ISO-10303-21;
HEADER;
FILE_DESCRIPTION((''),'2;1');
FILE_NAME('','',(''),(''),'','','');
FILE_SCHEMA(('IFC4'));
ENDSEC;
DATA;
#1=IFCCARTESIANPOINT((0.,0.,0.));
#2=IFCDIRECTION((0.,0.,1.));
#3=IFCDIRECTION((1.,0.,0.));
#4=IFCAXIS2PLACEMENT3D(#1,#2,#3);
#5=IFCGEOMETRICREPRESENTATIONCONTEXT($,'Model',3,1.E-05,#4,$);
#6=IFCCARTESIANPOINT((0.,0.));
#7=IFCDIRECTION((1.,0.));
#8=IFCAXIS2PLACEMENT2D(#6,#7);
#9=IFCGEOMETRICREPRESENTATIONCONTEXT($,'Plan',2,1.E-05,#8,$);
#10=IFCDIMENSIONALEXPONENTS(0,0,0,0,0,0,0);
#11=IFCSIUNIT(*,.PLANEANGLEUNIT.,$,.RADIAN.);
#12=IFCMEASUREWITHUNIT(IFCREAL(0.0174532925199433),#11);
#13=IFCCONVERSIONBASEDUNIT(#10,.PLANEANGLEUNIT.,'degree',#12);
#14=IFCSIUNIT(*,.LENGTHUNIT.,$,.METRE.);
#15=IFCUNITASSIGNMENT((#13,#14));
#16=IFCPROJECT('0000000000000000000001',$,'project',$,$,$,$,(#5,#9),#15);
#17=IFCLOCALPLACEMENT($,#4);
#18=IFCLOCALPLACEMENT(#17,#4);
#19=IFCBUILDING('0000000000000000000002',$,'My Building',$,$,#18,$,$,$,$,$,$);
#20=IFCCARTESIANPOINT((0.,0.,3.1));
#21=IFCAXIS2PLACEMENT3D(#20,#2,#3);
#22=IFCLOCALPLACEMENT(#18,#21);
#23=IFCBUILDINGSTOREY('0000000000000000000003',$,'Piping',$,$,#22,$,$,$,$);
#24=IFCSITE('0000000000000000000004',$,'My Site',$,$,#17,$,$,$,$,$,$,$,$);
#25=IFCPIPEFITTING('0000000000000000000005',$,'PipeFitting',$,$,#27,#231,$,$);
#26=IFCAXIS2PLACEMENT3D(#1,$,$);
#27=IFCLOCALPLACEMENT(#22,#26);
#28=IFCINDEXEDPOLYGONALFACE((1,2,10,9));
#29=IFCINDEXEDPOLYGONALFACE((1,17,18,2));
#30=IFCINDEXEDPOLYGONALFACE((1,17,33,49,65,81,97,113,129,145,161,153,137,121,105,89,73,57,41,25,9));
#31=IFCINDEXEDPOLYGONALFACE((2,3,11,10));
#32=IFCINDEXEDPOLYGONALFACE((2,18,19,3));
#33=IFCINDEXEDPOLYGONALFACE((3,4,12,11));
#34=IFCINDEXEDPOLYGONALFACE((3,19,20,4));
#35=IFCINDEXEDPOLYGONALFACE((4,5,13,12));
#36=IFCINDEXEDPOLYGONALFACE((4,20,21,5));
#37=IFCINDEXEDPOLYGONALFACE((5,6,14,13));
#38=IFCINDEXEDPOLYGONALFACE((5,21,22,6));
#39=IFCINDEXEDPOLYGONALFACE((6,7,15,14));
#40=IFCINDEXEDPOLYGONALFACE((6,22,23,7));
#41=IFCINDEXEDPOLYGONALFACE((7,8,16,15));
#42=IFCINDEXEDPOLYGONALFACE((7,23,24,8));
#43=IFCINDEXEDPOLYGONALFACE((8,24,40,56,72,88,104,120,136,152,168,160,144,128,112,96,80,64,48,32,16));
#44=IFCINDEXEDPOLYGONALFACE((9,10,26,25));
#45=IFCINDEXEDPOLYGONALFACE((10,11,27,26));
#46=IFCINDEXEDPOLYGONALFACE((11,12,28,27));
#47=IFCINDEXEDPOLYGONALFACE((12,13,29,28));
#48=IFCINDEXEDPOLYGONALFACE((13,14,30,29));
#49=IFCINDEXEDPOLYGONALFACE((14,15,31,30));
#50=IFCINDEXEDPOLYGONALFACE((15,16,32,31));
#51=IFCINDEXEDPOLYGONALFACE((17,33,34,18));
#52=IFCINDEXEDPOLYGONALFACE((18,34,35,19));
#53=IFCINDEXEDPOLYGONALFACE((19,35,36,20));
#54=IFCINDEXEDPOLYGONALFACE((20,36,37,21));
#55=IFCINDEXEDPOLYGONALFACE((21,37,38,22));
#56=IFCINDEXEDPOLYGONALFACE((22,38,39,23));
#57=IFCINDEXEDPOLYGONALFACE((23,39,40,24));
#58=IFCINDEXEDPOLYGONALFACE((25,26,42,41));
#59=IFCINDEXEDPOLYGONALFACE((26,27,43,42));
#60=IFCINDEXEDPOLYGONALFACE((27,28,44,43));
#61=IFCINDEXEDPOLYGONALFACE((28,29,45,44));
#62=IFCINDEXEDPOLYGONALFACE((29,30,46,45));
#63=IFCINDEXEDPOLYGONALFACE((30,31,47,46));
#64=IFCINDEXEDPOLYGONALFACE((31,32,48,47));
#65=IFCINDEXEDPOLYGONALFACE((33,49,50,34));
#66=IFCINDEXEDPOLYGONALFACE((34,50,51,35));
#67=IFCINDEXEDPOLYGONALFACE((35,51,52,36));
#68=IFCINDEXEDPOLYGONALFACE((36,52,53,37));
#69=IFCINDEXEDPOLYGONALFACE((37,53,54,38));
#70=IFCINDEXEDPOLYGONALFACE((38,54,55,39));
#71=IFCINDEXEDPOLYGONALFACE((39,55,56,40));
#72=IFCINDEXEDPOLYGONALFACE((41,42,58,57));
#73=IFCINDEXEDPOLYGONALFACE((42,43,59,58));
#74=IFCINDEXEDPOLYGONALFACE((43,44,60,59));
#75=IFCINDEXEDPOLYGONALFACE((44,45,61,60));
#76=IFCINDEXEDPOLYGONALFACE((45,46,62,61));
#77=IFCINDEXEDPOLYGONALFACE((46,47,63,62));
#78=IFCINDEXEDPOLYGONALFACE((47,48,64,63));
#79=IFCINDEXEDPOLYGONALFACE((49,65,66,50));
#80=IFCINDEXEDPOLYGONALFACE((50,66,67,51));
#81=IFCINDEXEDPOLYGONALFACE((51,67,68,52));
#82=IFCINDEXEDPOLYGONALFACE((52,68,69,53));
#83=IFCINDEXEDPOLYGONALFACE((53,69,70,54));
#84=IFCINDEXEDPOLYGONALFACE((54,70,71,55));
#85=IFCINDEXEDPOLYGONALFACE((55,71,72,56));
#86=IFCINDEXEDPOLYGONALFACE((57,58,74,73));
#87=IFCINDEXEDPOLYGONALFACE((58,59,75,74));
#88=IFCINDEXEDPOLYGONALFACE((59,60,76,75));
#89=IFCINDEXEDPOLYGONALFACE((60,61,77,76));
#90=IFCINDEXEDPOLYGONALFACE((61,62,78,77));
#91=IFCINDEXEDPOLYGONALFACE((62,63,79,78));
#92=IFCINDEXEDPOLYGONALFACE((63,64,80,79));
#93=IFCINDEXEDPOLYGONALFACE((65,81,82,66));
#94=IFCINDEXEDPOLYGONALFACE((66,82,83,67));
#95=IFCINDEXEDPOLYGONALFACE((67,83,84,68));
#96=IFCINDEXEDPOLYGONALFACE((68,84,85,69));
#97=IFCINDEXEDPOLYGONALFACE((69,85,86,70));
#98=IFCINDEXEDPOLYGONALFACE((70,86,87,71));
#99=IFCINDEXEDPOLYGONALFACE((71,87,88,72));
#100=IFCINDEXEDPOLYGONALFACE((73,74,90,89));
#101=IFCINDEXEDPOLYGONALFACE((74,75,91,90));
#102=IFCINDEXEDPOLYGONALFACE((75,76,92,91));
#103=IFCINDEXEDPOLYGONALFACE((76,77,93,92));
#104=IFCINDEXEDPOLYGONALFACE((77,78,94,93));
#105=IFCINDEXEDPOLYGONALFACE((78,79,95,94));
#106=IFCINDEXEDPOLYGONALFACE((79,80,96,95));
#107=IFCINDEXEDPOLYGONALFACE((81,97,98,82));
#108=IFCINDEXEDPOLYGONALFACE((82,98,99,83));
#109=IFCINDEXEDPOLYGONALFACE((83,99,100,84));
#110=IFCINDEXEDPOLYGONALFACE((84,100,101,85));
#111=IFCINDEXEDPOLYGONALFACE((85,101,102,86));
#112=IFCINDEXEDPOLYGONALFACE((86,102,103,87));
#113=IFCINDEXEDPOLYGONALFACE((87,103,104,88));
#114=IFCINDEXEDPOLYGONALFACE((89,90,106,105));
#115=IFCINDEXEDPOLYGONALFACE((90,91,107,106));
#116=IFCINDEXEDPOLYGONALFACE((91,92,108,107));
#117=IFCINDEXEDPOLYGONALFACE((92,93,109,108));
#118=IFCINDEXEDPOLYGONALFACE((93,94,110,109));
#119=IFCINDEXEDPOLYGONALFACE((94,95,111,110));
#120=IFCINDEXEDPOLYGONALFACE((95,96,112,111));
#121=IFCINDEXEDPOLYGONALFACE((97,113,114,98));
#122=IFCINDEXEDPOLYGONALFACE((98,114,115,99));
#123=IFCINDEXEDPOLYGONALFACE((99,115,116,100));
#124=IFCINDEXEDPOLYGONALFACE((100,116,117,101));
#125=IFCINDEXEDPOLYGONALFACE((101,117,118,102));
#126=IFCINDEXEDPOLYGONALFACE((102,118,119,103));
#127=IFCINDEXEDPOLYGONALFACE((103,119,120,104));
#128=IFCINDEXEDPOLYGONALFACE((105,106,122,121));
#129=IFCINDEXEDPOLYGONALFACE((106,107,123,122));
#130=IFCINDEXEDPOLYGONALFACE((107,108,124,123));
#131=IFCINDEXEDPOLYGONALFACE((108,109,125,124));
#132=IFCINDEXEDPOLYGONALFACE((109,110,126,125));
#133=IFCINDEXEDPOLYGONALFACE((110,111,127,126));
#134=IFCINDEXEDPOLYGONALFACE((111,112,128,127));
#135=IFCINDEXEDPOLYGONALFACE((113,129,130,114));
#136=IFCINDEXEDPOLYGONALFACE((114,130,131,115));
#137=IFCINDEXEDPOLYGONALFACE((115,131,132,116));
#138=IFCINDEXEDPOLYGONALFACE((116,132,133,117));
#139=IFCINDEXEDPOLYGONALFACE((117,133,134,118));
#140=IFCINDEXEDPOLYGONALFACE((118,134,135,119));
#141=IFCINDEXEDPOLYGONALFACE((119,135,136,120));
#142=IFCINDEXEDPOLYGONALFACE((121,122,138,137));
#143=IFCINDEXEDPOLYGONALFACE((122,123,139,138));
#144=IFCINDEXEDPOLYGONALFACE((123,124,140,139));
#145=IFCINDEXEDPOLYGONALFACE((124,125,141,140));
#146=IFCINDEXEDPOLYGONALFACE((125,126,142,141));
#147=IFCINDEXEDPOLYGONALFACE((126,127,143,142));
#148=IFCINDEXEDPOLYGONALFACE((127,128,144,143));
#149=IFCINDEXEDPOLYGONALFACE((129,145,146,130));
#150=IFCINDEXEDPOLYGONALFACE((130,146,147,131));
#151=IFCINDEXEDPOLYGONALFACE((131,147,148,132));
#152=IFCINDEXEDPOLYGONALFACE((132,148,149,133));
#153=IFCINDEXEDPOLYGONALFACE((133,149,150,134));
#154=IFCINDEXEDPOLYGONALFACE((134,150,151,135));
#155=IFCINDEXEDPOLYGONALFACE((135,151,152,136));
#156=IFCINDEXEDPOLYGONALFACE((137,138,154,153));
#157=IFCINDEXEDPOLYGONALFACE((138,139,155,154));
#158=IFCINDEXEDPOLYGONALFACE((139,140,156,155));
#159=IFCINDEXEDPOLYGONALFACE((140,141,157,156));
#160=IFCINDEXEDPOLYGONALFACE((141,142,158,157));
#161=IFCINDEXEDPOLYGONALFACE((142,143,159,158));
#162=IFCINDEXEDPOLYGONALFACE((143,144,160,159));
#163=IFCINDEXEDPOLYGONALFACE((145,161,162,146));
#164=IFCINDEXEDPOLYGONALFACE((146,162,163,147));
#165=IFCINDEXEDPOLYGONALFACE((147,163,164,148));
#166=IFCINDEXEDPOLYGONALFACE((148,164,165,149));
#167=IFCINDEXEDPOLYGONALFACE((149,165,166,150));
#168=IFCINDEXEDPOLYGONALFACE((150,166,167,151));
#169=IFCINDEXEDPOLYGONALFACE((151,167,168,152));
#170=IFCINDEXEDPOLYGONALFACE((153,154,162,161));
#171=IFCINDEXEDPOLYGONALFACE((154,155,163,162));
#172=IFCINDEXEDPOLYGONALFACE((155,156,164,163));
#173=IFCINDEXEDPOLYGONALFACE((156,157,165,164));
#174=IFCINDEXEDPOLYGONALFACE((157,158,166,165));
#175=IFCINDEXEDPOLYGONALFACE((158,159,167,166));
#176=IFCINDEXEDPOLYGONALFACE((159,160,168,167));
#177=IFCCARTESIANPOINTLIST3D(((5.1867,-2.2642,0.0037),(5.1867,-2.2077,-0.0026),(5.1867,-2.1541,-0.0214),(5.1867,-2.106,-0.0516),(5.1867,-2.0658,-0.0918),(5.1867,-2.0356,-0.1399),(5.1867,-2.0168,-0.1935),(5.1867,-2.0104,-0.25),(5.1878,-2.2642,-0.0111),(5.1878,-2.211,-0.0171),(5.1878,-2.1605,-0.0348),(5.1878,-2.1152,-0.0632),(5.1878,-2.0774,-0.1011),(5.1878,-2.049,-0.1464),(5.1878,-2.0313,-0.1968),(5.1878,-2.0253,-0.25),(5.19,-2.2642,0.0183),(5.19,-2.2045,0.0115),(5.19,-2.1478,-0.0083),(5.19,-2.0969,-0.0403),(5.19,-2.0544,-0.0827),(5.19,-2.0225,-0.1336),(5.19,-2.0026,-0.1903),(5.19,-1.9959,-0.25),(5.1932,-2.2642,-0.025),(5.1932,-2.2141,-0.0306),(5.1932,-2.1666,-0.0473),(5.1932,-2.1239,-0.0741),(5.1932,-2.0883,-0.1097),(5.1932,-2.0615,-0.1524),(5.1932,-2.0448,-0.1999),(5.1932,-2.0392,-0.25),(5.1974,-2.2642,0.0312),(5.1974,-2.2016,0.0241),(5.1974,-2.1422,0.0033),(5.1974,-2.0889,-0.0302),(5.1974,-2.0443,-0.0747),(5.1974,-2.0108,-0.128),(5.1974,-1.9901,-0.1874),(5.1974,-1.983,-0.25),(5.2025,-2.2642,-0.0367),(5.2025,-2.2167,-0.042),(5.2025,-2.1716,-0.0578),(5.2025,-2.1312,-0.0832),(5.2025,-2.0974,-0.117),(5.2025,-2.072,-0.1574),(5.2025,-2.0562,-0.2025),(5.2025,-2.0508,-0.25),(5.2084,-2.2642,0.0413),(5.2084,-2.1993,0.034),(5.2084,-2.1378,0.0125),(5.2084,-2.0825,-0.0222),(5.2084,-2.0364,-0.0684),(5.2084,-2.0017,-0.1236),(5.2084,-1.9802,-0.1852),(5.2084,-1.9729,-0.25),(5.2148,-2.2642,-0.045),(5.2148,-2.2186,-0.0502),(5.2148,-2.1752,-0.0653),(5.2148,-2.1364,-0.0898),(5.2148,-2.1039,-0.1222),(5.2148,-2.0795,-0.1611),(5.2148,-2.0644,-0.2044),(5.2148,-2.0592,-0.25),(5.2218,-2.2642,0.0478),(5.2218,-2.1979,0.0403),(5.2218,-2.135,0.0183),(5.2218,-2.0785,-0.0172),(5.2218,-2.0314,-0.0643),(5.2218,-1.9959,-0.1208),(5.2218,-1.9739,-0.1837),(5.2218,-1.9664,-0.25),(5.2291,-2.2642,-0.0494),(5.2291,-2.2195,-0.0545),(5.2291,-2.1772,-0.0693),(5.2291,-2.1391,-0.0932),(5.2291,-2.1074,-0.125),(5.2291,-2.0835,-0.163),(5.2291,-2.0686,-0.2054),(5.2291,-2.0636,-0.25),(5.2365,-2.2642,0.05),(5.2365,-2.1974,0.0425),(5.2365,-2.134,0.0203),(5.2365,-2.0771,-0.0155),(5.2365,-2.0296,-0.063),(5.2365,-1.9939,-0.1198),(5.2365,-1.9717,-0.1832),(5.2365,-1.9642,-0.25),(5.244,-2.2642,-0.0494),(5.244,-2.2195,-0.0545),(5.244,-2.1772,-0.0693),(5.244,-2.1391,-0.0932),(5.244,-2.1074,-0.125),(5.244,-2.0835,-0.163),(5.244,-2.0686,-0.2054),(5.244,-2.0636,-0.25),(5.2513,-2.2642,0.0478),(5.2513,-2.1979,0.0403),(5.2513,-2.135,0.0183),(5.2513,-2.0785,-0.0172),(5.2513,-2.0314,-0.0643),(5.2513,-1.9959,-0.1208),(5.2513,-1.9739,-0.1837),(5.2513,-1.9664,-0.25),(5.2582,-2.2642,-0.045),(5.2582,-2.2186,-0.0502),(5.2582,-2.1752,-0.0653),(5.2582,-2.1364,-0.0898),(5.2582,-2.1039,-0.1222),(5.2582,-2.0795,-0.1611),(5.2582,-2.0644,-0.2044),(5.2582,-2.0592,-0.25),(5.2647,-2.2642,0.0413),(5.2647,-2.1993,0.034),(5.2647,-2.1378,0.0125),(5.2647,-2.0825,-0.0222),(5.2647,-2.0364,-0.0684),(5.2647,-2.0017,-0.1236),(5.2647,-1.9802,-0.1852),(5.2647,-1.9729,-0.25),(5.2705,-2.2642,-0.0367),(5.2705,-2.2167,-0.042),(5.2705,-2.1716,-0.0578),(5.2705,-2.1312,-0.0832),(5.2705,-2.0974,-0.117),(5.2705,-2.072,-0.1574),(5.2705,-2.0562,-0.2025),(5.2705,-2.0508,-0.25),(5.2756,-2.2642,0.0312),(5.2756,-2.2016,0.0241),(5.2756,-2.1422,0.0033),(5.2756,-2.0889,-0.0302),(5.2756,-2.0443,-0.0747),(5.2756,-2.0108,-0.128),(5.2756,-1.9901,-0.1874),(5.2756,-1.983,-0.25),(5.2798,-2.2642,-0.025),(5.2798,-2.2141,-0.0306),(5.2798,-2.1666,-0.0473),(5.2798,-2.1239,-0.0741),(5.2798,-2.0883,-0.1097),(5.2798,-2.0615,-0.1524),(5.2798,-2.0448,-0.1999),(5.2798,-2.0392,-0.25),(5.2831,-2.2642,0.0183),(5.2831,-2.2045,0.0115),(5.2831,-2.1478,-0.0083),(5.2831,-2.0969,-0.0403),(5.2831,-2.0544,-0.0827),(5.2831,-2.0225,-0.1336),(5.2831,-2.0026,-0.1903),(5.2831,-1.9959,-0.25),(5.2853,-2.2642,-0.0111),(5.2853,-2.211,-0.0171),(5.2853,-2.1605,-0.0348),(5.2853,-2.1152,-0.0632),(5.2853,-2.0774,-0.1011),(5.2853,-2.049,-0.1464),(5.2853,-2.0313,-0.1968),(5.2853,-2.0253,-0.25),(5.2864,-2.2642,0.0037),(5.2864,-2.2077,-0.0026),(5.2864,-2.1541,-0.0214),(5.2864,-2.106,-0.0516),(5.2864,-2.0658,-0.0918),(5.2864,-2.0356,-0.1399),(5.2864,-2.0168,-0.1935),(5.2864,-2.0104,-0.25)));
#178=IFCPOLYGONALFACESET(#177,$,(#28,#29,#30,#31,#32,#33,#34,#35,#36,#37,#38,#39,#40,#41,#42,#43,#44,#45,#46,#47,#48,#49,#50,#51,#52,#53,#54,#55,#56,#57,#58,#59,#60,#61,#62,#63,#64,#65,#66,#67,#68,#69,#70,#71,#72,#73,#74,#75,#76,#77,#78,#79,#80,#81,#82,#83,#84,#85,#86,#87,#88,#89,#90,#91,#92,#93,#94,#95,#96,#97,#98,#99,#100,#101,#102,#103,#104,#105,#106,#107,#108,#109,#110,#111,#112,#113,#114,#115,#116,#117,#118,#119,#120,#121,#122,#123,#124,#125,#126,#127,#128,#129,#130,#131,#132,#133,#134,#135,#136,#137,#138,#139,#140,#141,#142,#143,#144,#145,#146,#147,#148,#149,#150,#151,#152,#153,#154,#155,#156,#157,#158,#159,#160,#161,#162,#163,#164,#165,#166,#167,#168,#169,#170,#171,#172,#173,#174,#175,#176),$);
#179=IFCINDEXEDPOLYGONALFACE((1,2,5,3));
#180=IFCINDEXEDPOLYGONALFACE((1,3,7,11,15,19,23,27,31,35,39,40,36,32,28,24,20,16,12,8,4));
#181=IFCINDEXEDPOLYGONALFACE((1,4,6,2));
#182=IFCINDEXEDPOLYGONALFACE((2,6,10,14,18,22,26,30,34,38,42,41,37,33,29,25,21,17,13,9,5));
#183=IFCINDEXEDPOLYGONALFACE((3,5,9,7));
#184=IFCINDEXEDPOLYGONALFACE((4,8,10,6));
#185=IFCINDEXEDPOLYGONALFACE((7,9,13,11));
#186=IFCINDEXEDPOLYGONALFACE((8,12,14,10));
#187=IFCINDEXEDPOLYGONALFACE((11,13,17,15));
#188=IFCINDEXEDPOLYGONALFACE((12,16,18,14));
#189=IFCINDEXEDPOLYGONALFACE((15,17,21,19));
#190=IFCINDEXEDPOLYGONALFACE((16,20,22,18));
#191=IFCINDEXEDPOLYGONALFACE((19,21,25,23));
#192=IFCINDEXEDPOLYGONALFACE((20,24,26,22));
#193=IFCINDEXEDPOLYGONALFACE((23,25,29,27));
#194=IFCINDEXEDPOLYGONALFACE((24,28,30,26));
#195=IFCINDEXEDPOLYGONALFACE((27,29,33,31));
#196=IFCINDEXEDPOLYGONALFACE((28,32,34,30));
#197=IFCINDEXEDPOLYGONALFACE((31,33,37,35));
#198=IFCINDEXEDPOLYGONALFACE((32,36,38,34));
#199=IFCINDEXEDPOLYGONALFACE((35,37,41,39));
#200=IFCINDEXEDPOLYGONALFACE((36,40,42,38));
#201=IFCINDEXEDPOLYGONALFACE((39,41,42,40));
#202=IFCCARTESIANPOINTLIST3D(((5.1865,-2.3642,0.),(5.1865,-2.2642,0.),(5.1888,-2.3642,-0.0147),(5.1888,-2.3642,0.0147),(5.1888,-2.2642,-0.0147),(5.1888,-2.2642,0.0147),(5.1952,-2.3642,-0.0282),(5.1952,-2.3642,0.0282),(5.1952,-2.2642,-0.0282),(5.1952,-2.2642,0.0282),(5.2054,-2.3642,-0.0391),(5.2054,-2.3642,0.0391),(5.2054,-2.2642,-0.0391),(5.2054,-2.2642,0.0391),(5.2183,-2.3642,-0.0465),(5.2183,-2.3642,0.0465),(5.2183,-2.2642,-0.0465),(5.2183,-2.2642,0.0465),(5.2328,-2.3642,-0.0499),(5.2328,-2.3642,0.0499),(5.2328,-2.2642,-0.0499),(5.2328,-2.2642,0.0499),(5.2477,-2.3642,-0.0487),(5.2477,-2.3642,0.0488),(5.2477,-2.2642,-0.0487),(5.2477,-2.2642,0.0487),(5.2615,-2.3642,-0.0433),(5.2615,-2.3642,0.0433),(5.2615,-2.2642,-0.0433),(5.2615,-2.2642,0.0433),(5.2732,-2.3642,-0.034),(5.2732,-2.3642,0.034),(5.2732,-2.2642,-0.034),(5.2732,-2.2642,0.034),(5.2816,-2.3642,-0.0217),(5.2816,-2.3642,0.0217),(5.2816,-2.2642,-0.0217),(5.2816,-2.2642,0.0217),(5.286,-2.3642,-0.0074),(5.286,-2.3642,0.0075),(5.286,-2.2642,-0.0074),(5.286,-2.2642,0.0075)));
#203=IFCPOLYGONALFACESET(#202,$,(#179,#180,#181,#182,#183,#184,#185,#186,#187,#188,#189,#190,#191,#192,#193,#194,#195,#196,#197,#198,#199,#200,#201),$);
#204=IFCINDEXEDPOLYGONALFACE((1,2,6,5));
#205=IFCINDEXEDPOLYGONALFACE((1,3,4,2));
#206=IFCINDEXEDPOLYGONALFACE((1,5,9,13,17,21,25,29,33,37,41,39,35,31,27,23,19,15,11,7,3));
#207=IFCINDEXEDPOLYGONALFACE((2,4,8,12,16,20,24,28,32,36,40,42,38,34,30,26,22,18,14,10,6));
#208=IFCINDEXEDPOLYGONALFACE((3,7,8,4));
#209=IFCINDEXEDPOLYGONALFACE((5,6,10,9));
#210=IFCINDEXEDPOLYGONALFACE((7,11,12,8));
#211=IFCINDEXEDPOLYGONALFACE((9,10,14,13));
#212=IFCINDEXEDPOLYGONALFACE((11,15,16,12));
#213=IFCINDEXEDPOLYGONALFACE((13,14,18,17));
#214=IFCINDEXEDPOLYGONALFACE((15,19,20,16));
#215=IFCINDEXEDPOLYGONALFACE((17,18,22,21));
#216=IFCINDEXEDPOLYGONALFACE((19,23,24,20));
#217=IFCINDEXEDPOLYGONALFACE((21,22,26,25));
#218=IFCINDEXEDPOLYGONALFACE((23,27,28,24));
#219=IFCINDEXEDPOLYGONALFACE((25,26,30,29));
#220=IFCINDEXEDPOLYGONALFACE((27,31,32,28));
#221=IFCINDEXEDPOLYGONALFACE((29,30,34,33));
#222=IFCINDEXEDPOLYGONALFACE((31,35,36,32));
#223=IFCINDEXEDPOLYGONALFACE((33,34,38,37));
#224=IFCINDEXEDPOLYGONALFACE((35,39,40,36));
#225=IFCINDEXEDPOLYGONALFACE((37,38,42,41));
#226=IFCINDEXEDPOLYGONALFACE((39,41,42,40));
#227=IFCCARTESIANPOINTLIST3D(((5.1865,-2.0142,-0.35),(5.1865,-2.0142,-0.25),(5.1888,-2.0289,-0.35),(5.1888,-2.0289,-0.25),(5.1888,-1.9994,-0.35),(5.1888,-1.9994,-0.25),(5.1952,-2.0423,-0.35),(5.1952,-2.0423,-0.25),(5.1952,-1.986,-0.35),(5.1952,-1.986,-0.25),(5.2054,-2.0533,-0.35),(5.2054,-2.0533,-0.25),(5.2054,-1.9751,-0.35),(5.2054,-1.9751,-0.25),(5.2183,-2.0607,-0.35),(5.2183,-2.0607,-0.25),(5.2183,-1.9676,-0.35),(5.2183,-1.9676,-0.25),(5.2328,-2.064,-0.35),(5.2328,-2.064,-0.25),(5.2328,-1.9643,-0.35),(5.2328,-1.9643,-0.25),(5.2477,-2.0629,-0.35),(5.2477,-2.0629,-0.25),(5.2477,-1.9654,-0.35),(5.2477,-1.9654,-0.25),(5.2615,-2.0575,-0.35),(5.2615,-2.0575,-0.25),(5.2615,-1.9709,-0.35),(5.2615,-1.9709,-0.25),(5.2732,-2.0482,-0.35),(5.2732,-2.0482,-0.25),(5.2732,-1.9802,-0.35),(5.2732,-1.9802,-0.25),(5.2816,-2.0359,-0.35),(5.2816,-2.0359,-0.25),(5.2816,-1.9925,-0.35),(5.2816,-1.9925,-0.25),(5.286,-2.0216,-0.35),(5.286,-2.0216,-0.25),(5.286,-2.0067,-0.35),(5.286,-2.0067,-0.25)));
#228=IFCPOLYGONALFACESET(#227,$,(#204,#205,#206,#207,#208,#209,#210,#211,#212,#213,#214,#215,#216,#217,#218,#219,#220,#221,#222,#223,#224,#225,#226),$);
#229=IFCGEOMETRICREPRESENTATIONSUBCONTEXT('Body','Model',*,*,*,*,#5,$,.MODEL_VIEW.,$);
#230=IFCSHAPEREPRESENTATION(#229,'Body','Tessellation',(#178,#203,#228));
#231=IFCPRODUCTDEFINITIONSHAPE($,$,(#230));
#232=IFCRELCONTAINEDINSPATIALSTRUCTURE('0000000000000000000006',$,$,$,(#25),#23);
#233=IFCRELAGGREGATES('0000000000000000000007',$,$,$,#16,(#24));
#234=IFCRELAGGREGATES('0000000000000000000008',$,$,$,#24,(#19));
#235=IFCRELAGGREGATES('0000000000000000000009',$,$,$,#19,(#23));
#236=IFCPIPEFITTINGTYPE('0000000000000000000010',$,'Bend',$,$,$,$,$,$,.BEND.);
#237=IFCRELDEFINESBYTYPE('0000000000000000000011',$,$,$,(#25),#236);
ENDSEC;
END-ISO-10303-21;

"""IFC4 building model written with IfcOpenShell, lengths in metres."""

from ifc_helpers import new_model, entity, si_unit, converted_unit, frame, origin_with_axes, origin_2d_with_axis, place, context, subcontext, project, spatial, circle, extrude, source, transform, mapped, type_object, type_shapes, element, save


model = new_model("IFC4")

# Units and contexts
model_context = context("Model", 3, precision=1e-05, world=origin_with_axes())
plan_context = context("Plan", 2, precision=1e-05, world=origin_2d_with_axis())
body_context = subcontext(model_context, "Body", "Model", "MODEL_VIEW")
ifc_project = project(units=[converted_unit("PLANEANGLEUNIT", "degree", entity("IfcReal", 0.0174532925199433), si_unit("PLANEANGLEUNIT", "RADIAN"), dimensions=[0, 0, 0, 0, 0, 0, 0]), si_unit("LENGTHUNIT", "METRE")], contexts=[model_context, plan_context])

# Site, building, storey
site_placement = place(None, origin_with_axes())
site = spatial("IfcSite", under=ifc_project, at=site_placement, Name="My Site")
building_placement = place(site_placement, origin_with_axes())
building = spatial("IfcBuilding", under=site, at=building_placement, Name="My Building")
storey_placement = place(building_placement, frame((0.0, 0.0, 3.1), z_axis=(0.0, 0.0, 1.0), x_axis=(1.0, 0.0, 0.0)))
storey = spatial("IfcBuildingStorey", under=building, at=storey_placement, Name="Piping")

# Pipe fitting
pipe_fitting_type_1 = type_object("IfcPipeFittingType", Name="Bend", PredefinedType="BEND")
shared_shape_1 = source(origin_with_axes(), body_context, "Body", "SolidModel", [
    entity("IfcSweptDiskSolid", entity("IfcIndexedPolyCurve", entity("IfcCartesianPointList3D", [[0.0, 0.0, 0.1], [0.0, -0.0732, 0.2768], [0.0, -0.25, 0.35]]), [entity("IfcArcIndex", [1, 2, 3])]), 0.05),
    extrude(circle(Radius=0.05), origin_with_axes(), (0.0, 0.0, 1.0), 0.1),
    extrude(circle(Radius=0.05), frame((0.0, -0.25, 0.35), z_axis=(0.0, -1.0, 0.000022), x_axis=(1.0, 0.0, 0.0)), (0.0, 0.0, 1.0), 0.1),
])
type_shapes(pipe_fitting_type_1, [shared_shape_1])
for number, where, z_axis, x_axis, name in (
    (1, (5.2365, -2.3642, 0.0), (0.0, 1.0, -0.000022), (-1.0, 0.0, 0.0), "PipeFitting"),
):
    element("IfcPipeFitting", number, at=place(storey_placement, frame(where, z_axis=z_axis, x_axis=x_axis)), inside=storey, type_object=pipe_fitting_type_1, Name=name, context=body_context, shape_type="MappedRepresentation", body=[
        mapped(shared_shape_1, transform((0.0, 0.0, 0.0), x_axis=(1.0, 0.0, 0.0), y_axis=(0.0, 1.0, 0.0), z_axis=(0.0, 0.0, 1.0), scale=1.0)),
    ])

save(model, "model.ifc")
